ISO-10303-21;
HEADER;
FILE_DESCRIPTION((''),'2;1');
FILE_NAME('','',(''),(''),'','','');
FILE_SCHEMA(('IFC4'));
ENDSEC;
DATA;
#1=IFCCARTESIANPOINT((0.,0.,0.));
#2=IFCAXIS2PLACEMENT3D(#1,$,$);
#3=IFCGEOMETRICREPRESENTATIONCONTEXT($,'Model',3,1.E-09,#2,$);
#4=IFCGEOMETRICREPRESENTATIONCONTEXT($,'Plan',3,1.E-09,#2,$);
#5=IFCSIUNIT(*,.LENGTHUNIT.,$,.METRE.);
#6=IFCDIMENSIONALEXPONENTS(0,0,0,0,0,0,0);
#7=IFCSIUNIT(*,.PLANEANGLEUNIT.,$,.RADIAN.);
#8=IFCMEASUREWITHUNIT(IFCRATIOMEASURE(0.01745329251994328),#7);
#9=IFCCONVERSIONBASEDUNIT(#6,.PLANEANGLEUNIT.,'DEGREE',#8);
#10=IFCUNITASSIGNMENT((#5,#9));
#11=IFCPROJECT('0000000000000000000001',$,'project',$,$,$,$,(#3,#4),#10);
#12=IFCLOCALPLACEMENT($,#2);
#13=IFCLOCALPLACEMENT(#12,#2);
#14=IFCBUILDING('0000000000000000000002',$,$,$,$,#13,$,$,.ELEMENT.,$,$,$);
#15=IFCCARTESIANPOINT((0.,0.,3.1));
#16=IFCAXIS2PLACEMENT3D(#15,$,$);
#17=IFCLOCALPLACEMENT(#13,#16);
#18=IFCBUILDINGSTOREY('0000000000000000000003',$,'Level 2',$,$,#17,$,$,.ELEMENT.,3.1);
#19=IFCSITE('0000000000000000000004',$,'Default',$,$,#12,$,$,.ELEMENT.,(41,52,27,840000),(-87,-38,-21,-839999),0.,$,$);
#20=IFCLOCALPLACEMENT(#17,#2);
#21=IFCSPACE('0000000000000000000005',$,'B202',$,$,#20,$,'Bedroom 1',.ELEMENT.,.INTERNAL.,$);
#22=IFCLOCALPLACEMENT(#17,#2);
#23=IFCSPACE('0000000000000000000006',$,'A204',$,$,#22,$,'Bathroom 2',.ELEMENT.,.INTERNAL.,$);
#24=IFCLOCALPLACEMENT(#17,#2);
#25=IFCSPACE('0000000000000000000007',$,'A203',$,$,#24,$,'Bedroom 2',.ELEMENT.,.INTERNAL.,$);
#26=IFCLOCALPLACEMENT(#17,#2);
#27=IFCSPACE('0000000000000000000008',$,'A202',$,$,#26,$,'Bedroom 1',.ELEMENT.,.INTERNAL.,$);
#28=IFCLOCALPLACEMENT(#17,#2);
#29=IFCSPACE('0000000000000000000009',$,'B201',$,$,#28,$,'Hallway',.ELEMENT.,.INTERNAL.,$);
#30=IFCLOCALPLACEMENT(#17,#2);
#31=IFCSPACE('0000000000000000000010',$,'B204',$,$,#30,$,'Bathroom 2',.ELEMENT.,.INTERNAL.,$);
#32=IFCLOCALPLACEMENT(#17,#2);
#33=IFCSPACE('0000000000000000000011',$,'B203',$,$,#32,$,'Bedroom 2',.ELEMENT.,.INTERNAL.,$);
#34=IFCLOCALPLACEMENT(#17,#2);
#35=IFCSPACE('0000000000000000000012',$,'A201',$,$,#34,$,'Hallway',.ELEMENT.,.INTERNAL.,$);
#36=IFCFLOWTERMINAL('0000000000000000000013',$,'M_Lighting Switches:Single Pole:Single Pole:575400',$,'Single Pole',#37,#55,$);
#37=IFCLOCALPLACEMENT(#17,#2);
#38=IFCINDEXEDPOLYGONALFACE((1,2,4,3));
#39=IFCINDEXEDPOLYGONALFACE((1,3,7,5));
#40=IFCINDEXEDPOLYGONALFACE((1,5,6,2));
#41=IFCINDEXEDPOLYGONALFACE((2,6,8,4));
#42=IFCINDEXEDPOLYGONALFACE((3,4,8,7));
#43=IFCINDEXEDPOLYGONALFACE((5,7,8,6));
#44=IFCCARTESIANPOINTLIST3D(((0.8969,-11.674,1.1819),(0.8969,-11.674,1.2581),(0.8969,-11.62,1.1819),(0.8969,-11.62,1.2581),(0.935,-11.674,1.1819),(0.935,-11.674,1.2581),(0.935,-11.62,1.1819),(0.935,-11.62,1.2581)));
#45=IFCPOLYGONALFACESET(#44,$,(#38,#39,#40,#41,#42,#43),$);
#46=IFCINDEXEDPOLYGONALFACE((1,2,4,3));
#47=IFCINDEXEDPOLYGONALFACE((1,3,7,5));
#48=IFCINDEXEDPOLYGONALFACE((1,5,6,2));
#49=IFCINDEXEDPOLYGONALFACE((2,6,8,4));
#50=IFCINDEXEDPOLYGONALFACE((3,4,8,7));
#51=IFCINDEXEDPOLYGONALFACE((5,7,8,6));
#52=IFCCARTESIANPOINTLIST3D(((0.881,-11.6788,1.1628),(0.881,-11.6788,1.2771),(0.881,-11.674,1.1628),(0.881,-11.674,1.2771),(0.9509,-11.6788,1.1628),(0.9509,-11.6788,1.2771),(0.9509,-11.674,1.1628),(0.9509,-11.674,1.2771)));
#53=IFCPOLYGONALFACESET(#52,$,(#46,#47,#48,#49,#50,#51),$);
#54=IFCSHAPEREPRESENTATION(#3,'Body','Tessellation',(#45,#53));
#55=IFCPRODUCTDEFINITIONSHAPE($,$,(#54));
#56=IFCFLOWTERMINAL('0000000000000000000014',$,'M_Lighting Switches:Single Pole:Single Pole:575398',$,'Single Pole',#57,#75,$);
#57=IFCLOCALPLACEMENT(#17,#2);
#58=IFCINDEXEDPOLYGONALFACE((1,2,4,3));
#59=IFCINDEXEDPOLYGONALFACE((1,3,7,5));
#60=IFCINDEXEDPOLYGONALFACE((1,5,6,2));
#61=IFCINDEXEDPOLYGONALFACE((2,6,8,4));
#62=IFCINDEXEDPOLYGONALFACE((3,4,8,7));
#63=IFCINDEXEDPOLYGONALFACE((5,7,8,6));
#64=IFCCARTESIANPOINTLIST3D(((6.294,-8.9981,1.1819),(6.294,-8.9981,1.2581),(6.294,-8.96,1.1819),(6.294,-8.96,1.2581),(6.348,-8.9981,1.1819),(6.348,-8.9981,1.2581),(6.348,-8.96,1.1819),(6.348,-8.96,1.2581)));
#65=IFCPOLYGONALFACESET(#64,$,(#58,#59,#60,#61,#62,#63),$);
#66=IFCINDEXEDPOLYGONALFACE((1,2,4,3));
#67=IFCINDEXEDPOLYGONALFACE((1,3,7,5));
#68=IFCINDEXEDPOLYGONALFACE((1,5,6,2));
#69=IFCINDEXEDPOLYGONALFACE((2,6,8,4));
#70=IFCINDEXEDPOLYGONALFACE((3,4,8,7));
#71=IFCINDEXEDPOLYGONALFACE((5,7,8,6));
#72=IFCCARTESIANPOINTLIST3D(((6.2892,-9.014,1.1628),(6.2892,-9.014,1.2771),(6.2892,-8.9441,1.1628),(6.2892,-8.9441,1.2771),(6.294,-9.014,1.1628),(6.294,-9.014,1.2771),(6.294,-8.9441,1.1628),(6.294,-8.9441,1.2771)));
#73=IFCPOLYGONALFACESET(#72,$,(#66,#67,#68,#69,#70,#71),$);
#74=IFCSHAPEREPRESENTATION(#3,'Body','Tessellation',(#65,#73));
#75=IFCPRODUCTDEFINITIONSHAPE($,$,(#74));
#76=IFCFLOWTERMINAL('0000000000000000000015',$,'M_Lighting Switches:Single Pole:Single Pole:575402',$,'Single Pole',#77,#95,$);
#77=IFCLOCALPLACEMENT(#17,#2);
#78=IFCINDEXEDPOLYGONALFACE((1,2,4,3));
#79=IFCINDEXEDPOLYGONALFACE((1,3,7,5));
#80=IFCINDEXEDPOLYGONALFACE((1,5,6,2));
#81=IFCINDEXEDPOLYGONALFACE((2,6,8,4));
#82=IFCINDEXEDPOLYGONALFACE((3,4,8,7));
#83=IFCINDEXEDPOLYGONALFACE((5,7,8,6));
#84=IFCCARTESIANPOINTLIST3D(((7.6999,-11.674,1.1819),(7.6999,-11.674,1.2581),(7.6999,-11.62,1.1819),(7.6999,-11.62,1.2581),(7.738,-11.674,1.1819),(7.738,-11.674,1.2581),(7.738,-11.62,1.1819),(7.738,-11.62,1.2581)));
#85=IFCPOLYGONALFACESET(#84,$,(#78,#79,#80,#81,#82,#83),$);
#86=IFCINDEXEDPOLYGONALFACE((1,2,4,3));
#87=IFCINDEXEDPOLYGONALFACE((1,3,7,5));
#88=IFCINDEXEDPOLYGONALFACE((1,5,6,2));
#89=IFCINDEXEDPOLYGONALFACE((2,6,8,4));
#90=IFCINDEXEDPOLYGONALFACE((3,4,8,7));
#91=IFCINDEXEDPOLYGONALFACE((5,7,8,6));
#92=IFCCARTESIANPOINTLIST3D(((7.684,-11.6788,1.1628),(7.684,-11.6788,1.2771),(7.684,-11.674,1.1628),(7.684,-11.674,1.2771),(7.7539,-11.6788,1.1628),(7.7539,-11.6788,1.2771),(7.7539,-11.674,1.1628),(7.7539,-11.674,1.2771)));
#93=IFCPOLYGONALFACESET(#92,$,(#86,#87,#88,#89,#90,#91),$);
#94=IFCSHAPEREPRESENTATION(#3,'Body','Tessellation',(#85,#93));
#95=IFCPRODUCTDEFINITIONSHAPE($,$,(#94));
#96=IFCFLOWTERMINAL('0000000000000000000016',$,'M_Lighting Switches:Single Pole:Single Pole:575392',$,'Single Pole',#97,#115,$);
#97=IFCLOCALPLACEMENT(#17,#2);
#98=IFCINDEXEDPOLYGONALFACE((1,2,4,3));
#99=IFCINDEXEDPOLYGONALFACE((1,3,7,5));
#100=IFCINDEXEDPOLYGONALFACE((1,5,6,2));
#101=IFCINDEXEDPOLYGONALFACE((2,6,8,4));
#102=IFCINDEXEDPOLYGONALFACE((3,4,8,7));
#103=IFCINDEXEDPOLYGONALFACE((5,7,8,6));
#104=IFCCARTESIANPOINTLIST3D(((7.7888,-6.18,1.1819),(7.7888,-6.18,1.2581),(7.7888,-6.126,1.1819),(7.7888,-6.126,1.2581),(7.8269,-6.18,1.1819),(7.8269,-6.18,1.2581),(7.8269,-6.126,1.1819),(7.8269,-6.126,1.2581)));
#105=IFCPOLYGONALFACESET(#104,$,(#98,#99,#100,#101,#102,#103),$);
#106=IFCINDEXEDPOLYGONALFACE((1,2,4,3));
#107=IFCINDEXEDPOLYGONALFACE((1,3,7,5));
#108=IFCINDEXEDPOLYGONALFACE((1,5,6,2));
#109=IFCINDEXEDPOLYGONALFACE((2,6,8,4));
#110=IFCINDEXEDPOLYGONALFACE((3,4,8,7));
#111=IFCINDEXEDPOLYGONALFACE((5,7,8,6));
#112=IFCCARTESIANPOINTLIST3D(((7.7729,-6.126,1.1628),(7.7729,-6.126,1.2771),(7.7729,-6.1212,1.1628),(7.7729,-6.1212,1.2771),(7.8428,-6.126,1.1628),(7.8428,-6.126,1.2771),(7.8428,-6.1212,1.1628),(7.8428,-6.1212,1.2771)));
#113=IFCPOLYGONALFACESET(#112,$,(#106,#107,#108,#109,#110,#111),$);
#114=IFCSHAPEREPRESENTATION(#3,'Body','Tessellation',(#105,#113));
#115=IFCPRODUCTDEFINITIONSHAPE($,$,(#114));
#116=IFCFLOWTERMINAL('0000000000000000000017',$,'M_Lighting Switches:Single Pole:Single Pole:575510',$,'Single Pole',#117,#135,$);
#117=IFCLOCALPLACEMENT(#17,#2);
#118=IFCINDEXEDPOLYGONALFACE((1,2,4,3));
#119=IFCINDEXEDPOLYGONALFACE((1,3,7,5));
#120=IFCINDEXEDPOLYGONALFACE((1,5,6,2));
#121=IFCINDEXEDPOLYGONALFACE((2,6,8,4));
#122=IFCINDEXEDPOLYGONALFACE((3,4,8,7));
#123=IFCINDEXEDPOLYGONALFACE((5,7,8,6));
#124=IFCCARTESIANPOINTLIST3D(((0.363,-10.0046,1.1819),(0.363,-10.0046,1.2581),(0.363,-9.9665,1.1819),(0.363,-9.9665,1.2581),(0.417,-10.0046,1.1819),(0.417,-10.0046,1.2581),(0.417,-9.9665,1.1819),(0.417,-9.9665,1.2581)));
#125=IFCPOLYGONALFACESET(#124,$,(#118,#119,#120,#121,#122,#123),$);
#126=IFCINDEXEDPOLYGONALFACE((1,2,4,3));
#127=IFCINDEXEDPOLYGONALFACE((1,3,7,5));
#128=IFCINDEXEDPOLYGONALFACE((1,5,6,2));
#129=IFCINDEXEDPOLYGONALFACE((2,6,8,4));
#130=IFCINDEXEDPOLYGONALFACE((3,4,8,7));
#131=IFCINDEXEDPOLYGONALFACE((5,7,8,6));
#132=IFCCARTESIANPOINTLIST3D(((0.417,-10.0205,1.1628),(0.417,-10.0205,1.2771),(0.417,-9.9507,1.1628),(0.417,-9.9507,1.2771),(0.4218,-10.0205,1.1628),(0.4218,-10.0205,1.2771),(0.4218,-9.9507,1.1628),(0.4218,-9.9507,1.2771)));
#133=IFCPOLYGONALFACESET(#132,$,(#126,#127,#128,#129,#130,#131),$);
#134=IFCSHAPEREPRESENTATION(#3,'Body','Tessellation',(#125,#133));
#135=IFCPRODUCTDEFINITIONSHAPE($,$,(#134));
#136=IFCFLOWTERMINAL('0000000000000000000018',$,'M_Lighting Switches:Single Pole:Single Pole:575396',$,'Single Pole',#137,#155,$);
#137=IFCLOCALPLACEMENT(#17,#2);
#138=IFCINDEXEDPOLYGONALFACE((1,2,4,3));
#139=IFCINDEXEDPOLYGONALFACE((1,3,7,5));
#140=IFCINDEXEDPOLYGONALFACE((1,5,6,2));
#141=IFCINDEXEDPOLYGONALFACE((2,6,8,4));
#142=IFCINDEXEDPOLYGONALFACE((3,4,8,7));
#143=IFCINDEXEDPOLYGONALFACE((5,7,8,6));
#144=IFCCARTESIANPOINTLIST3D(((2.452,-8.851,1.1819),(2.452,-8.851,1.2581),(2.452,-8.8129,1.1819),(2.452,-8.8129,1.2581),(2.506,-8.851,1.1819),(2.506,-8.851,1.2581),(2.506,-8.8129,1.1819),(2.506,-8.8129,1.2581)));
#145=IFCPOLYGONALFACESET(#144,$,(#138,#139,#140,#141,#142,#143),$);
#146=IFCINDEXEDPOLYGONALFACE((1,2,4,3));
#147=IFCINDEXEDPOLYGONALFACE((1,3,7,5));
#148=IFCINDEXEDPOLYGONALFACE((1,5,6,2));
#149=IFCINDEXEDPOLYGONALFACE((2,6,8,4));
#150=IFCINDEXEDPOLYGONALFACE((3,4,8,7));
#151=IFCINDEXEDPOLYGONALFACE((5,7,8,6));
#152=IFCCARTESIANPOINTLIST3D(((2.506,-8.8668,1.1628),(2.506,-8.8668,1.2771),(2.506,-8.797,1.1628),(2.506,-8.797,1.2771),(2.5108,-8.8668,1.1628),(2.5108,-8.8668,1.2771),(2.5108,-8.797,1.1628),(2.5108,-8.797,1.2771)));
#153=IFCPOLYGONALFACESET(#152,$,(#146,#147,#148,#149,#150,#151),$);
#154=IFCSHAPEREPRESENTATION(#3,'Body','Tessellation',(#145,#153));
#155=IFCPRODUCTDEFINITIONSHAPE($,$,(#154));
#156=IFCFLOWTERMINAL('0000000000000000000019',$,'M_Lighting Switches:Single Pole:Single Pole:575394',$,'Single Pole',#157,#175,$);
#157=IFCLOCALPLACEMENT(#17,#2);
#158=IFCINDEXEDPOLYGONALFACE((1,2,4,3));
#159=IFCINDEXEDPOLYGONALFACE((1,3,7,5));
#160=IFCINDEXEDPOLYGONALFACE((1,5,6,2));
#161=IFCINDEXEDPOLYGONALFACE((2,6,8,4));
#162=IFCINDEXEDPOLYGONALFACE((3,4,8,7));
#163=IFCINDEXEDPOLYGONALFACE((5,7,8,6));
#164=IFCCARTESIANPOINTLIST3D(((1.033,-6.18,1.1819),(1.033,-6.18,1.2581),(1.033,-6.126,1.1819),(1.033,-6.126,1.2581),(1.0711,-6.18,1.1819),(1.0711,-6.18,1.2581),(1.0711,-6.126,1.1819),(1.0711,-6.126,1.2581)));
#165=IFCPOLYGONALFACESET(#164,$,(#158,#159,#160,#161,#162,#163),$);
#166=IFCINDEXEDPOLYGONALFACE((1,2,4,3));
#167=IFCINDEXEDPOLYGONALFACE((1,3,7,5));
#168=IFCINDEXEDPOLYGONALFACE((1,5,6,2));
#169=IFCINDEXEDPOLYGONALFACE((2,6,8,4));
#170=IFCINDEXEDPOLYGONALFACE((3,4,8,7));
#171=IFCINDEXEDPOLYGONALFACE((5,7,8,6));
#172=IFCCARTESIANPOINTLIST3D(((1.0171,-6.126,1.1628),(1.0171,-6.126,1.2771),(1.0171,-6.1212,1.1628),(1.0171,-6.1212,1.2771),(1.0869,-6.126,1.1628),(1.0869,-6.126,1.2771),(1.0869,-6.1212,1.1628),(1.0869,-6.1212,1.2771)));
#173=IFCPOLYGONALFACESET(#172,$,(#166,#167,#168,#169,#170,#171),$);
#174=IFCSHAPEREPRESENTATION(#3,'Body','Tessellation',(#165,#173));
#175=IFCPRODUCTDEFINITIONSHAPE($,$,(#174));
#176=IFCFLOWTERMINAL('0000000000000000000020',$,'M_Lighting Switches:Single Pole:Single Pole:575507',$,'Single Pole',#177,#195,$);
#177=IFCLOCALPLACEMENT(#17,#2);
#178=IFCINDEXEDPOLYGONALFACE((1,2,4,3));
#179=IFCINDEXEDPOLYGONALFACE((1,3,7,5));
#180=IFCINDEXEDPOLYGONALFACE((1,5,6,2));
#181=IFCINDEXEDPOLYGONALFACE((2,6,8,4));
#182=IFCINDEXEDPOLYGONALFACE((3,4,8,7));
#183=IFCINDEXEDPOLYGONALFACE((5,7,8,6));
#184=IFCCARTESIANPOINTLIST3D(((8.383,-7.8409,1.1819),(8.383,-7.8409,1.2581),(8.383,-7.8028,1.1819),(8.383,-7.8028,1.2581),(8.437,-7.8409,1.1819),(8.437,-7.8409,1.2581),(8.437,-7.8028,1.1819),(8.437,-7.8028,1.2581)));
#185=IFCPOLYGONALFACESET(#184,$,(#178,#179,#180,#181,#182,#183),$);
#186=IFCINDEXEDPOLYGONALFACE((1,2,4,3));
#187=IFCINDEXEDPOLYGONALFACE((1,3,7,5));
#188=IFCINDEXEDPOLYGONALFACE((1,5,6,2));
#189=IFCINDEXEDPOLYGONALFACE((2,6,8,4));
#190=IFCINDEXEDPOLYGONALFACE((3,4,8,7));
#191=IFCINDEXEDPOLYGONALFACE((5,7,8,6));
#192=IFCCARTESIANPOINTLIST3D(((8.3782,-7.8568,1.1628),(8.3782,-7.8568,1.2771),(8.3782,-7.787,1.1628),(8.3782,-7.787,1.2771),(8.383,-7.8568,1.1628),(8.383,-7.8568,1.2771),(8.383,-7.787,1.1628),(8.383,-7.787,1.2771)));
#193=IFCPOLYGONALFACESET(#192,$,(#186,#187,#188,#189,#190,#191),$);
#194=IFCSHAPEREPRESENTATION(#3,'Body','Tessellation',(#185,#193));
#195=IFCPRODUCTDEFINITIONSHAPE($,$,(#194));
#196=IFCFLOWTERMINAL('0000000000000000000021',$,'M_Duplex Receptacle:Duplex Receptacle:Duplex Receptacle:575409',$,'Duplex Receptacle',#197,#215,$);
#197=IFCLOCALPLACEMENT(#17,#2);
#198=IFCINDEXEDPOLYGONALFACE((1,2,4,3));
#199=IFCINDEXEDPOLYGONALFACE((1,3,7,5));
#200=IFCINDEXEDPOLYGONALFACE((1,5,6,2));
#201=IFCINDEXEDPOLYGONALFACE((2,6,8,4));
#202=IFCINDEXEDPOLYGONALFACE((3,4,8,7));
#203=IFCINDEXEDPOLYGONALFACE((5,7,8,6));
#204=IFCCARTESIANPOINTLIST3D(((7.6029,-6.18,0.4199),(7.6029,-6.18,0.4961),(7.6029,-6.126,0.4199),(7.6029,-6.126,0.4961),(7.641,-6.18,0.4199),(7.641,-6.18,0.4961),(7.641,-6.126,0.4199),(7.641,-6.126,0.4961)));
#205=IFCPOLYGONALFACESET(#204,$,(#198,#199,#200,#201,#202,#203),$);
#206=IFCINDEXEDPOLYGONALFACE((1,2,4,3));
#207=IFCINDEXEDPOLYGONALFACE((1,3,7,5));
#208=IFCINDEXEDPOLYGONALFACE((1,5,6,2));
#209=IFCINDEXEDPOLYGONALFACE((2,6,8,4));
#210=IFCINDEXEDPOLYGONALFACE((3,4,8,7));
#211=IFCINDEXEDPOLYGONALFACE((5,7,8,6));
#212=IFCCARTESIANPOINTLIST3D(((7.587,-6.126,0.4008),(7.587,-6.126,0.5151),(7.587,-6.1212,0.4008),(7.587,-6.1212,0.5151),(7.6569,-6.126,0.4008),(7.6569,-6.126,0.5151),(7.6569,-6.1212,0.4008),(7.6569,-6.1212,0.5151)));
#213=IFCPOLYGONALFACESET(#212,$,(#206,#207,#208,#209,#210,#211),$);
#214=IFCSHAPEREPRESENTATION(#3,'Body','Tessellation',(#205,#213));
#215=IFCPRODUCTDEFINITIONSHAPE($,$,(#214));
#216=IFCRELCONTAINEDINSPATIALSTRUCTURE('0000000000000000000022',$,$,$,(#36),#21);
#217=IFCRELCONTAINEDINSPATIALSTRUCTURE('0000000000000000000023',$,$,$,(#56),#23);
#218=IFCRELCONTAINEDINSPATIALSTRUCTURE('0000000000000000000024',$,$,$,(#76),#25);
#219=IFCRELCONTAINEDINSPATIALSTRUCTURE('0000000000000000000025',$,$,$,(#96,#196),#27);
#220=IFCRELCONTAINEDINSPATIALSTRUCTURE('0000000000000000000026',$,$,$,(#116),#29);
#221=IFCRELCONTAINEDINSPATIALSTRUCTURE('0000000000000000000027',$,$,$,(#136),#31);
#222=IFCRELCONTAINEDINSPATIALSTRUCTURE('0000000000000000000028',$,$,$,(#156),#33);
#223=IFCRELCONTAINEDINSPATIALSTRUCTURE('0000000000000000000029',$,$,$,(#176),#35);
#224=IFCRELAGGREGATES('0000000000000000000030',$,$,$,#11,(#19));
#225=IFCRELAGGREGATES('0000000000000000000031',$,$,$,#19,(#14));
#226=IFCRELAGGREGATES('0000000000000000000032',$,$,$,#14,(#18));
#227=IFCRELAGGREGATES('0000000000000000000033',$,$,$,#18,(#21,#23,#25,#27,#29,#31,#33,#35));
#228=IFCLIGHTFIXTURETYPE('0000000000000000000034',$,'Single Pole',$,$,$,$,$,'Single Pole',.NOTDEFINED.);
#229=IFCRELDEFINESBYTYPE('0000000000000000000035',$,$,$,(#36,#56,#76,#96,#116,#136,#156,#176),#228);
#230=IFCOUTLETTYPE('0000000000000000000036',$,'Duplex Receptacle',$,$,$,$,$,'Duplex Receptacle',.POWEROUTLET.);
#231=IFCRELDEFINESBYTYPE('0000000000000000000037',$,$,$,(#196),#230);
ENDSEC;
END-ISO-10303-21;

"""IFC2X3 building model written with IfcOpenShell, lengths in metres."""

from ifc_helpers import new_model, entity, si_unit, converted_unit, frame, origin, origin_2d_with_axis, place, context, project, spatial, rectangle, extrude, source, transform, mapped, type_object, type_shapes, element, save


model = new_model("IFC2X3")

# Units and contexts
model_context = context("Model", 3, precision=1e-09, world=origin())
plan_context = context("Plan", 3, precision=1e-09, world=origin())
ifc_project = project(units=[si_unit("LENGTHUNIT", "METRE"), converted_unit("PLANEANGLEUNIT", "DEGREE", entity("IfcRatioMeasure", 0.01745329251994328), si_unit("PLANEANGLEUNIT", "RADIAN"), dimensions=[0, 0, 0, 0, 0, 0, 0])], contexts=[model_context, plan_context])

# Site, building, storey, space
site_placement = place(None, origin())
site = spatial("IfcSite", under=ifc_project, at=site_placement, Name="Default", CompositionType="ELEMENT", RefLatitude=(41, 52, 27, 840000), RefLongitude=(-87, -38, -21, -839999), RefElevation=0.0)
building_placement = place(site_placement, origin())
building = spatial("IfcBuilding", under=site, at=building_placement, CompositionType="ELEMENT")
storey_placement = place(building_placement, frame((0.0, 0.0, 3.1)))
storey = spatial("IfcBuildingStorey", under=building, at=storey_placement, Name="Level 2", CompositionType="ELEMENT", Elevation=3.1)
space_1_placement = place(storey_placement, origin())
space_1 = spatial("IfcSpace", under=storey, at=space_1_placement, Name="B202", LongName="Bedroom 1", CompositionType="ELEMENT", InteriorOrExteriorSpace="INTERNAL")

# Flow terminal
light_fixture_type = type_object("IfcLightFixtureType", Name="Single Pole", ElementType="Single Pole", PredefinedType="NOTDEFINED")
shared_shape_1 = source(origin(), model_context, "Body", "SweptSolid", [
    extrude(rectangle(XDim=0.0381, YDim=0.0762, at=origin_2d_with_axis()), frame((0.0, 0.0, -0.054), z_axis=(0.0, 0.0, 1.0), x_axis=(-1.0, 0.0, 0.0)), (0.0, 0.0, 1.0), 0.054),
    extrude(rectangle(XDim=0.0698, YDim=0.1143, at=origin_2d_with_axis()), frame((0.0, 0.0, 0.0), z_axis=(0.0, 0.0, 1.0), x_axis=(-1.0, 0.0, 0.0)), (0.0, 0.0, 1.0), 0.0048),
])
type_shapes(light_fixture_type, [shared_shape_1])
flow_terminal_1_placement = place(space_1_placement, frame((0.916, -11.674, 1.22), z_axis=(0.0, -1.0, 0.0), x_axis=(1.0, 0.0, 0.0)))
element("IfcFlowTerminal", 1, at=flow_terminal_1_placement, inside=space_1, type_object=light_fixture_type, Name="M_Lighting Switches:Single Pole:Single Pole:575400", ObjectType="Single Pole", context=model_context, shape_type="MappedRepresentation", body=[
    mapped(shared_shape_1, transform((0.0, 0.0, 0.0), scale=1.0)),
])

# Shared definitions
space_2_placement = place(storey_placement, origin())
space_2 = spatial("IfcSpace", under=storey, at=space_2_placement, Name="A204", LongName="Bathroom 2", CompositionType="ELEMENT", InteriorOrExteriorSpace="INTERNAL")

# Flow terminal
flow_terminal_2_placement = place(space_2_placement, frame((6.294, -8.9791, 1.22), z_axis=(-1.0, 0.0, 0.0), x_axis=(0.0, -1.0, 0.0)))
element("IfcFlowTerminal", 2, at=flow_terminal_2_placement, inside=space_2, type_object=light_fixture_type, Name="M_Lighting Switches:Single Pole:Single Pole:575398", ObjectType="Single Pole", context=model_context, shape_type="MappedRepresentation", body=[
    mapped(shared_shape_1, transform((0.0, 0.0, 0.0), scale=1.0)),
])

# Shared definitions
space_3_placement = place(storey_placement, origin())
space_3 = spatial("IfcSpace", under=storey, at=space_3_placement, Name="A203", LongName="Bedroom 2", CompositionType="ELEMENT", InteriorOrExteriorSpace="INTERNAL")

# Flow terminal
flow_terminal_3_placement = place(space_3_placement, frame((7.719, -11.674, 1.22), z_axis=(0.0, -1.0, 0.0), x_axis=(1.0, 0.0, 0.0)))
element("IfcFlowTerminal", 3, at=flow_terminal_3_placement, inside=space_3, type_object=light_fixture_type, Name="M_Lighting Switches:Single Pole:Single Pole:575402", ObjectType="Single Pole", context=model_context, shape_type="MappedRepresentation", body=[
    mapped(shared_shape_1, transform((0.0, 0.0, 0.0), scale=1.0)),
])

# Shared definitions
space_4_placement = place(storey_placement, origin())
space_4 = spatial("IfcSpace", under=storey, at=space_4_placement, Name="A202", LongName="Bedroom 1", CompositionType="ELEMENT", InteriorOrExteriorSpace="INTERNAL")

# Flow terminal
flow_terminal_4_placement = place(space_4_placement, frame((7.8079, -6.126, 1.22), z_axis=(0.0, 1.0, 0.0), x_axis=(-1.0, 0.0, 0.0)))
element("IfcFlowTerminal", 4, at=flow_terminal_4_placement, inside=space_4, type_object=light_fixture_type, Name="M_Lighting Switches:Single Pole:Single Pole:575392", ObjectType="Single Pole", context=model_context, shape_type="MappedRepresentation", body=[
    mapped(shared_shape_1, transform((0.0, 0.0, 0.0), scale=1.0)),
])

# Shared definitions
space_5_placement = place(storey_placement, origin())
space_5 = spatial("IfcSpace", under=storey, at=space_5_placement, Name="B201", LongName="Hallway", CompositionType="ELEMENT", InteriorOrExteriorSpace="INTERNAL")

# Flow terminal
flow_terminal_5_placement = place(space_5_placement, frame((0.417, -9.9856, 1.22), z_axis=(1.0, 0.0, 0.0), x_axis=(0.0, 1.0, 0.0)))
element("IfcFlowTerminal", 5, at=flow_terminal_5_placement, inside=space_5, type_object=light_fixture_type, Name="M_Lighting Switches:Single Pole:Single Pole:575510", ObjectType="Single Pole", context=model_context, shape_type="MappedRepresentation", body=[
    mapped(shared_shape_1, transform((0.0, 0.0, 0.0), scale=1.0)),
])

# Shared definitions
space_6_placement = place(storey_placement, origin())
space_6 = spatial("IfcSpace", under=storey, at=space_6_placement, Name="B204", LongName="Bathroom 2", CompositionType="ELEMENT", InteriorOrExteriorSpace="INTERNAL")

# Flow terminal
flow_terminal_6_placement = place(space_6_placement, frame((2.506, -8.8319, 1.22), z_axis=(1.0, 0.0, 0.0), x_axis=(0.0, 1.0, 0.0)))
element("IfcFlowTerminal", 6, at=flow_terminal_6_placement, inside=space_6, type_object=light_fixture_type, Name="M_Lighting Switches:Single Pole:Single Pole:575396", ObjectType="Single Pole", context=model_context, shape_type="MappedRepresentation", body=[
    mapped(shared_shape_1, transform((0.0, 0.0, 0.0), scale=1.0)),
])

# Shared definitions
space_7_placement = place(storey_placement, origin())
space_7 = spatial("IfcSpace", under=storey, at=space_7_placement, Name="B203", LongName="Bedroom 2", CompositionType="ELEMENT", InteriorOrExteriorSpace="INTERNAL")

# Flow terminal
flow_terminal_7_placement = place(space_7_placement, frame((1.052, -6.126, 1.22), z_axis=(0.0, 1.0, 0.0), x_axis=(-1.0, 0.0, 0.0)))
element("IfcFlowTerminal", 7, at=flow_terminal_7_placement, inside=space_7, type_object=light_fixture_type, Name="M_Lighting Switches:Single Pole:Single Pole:575394", ObjectType="Single Pole", context=model_context, shape_type="MappedRepresentation", body=[
    mapped(shared_shape_1, transform((0.0, 0.0, 0.0), scale=1.0)),
])

# Shared definitions
space_8_placement = place(storey_placement, origin())
space_8 = spatial("IfcSpace", under=storey, at=space_8_placement, Name="A201", LongName="Hallway", CompositionType="ELEMENT", InteriorOrExteriorSpace="INTERNAL")

# Flow terminals
flow_terminal_8_placement = place(space_8_placement, frame((8.383, -7.8219, 1.22), z_axis=(-1.0, 0.0, 0.0), x_axis=(0.0, -1.0, 0.0)))
element("IfcFlowTerminal", 8, at=flow_terminal_8_placement, inside=space_8, type_object=light_fixture_type, Name="M_Lighting Switches:Single Pole:Single Pole:575507", ObjectType="Single Pole", context=model_context, shape_type="MappedRepresentation", body=[
    mapped(shared_shape_1, transform((0.0, 0.0, 0.0), scale=1.0)),
])
outlet_type = type_object("IfcOutletType", Name="Duplex Receptacle", ElementType="Duplex Receptacle", PredefinedType="POWEROUTLET")
type_shapes(outlet_type, [shared_shape_1])
for number, where, z_axis, x_axis, name in (
    (9, (7.622, -6.126, 0.458), (0.0, 1.0, 0.0), (-1.0, 0.0, 0.0), "M_Duplex Receptacle:Duplex Receptacle:Duplex Receptacle:575409"),
):
    element("IfcFlowTerminal", number, at=place(space_4_placement, frame(where, z_axis=z_axis, x_axis=x_axis)), inside=space_4, type_object=outlet_type, Name=name, ObjectType="Duplex Receptacle", context=model_context, shape_type="MappedRepresentation", body=[
        mapped(shared_shape_1, transform((0.0, 0.0, 0.0), scale=1.0)),
    ])

save(model, "model.ifc")
